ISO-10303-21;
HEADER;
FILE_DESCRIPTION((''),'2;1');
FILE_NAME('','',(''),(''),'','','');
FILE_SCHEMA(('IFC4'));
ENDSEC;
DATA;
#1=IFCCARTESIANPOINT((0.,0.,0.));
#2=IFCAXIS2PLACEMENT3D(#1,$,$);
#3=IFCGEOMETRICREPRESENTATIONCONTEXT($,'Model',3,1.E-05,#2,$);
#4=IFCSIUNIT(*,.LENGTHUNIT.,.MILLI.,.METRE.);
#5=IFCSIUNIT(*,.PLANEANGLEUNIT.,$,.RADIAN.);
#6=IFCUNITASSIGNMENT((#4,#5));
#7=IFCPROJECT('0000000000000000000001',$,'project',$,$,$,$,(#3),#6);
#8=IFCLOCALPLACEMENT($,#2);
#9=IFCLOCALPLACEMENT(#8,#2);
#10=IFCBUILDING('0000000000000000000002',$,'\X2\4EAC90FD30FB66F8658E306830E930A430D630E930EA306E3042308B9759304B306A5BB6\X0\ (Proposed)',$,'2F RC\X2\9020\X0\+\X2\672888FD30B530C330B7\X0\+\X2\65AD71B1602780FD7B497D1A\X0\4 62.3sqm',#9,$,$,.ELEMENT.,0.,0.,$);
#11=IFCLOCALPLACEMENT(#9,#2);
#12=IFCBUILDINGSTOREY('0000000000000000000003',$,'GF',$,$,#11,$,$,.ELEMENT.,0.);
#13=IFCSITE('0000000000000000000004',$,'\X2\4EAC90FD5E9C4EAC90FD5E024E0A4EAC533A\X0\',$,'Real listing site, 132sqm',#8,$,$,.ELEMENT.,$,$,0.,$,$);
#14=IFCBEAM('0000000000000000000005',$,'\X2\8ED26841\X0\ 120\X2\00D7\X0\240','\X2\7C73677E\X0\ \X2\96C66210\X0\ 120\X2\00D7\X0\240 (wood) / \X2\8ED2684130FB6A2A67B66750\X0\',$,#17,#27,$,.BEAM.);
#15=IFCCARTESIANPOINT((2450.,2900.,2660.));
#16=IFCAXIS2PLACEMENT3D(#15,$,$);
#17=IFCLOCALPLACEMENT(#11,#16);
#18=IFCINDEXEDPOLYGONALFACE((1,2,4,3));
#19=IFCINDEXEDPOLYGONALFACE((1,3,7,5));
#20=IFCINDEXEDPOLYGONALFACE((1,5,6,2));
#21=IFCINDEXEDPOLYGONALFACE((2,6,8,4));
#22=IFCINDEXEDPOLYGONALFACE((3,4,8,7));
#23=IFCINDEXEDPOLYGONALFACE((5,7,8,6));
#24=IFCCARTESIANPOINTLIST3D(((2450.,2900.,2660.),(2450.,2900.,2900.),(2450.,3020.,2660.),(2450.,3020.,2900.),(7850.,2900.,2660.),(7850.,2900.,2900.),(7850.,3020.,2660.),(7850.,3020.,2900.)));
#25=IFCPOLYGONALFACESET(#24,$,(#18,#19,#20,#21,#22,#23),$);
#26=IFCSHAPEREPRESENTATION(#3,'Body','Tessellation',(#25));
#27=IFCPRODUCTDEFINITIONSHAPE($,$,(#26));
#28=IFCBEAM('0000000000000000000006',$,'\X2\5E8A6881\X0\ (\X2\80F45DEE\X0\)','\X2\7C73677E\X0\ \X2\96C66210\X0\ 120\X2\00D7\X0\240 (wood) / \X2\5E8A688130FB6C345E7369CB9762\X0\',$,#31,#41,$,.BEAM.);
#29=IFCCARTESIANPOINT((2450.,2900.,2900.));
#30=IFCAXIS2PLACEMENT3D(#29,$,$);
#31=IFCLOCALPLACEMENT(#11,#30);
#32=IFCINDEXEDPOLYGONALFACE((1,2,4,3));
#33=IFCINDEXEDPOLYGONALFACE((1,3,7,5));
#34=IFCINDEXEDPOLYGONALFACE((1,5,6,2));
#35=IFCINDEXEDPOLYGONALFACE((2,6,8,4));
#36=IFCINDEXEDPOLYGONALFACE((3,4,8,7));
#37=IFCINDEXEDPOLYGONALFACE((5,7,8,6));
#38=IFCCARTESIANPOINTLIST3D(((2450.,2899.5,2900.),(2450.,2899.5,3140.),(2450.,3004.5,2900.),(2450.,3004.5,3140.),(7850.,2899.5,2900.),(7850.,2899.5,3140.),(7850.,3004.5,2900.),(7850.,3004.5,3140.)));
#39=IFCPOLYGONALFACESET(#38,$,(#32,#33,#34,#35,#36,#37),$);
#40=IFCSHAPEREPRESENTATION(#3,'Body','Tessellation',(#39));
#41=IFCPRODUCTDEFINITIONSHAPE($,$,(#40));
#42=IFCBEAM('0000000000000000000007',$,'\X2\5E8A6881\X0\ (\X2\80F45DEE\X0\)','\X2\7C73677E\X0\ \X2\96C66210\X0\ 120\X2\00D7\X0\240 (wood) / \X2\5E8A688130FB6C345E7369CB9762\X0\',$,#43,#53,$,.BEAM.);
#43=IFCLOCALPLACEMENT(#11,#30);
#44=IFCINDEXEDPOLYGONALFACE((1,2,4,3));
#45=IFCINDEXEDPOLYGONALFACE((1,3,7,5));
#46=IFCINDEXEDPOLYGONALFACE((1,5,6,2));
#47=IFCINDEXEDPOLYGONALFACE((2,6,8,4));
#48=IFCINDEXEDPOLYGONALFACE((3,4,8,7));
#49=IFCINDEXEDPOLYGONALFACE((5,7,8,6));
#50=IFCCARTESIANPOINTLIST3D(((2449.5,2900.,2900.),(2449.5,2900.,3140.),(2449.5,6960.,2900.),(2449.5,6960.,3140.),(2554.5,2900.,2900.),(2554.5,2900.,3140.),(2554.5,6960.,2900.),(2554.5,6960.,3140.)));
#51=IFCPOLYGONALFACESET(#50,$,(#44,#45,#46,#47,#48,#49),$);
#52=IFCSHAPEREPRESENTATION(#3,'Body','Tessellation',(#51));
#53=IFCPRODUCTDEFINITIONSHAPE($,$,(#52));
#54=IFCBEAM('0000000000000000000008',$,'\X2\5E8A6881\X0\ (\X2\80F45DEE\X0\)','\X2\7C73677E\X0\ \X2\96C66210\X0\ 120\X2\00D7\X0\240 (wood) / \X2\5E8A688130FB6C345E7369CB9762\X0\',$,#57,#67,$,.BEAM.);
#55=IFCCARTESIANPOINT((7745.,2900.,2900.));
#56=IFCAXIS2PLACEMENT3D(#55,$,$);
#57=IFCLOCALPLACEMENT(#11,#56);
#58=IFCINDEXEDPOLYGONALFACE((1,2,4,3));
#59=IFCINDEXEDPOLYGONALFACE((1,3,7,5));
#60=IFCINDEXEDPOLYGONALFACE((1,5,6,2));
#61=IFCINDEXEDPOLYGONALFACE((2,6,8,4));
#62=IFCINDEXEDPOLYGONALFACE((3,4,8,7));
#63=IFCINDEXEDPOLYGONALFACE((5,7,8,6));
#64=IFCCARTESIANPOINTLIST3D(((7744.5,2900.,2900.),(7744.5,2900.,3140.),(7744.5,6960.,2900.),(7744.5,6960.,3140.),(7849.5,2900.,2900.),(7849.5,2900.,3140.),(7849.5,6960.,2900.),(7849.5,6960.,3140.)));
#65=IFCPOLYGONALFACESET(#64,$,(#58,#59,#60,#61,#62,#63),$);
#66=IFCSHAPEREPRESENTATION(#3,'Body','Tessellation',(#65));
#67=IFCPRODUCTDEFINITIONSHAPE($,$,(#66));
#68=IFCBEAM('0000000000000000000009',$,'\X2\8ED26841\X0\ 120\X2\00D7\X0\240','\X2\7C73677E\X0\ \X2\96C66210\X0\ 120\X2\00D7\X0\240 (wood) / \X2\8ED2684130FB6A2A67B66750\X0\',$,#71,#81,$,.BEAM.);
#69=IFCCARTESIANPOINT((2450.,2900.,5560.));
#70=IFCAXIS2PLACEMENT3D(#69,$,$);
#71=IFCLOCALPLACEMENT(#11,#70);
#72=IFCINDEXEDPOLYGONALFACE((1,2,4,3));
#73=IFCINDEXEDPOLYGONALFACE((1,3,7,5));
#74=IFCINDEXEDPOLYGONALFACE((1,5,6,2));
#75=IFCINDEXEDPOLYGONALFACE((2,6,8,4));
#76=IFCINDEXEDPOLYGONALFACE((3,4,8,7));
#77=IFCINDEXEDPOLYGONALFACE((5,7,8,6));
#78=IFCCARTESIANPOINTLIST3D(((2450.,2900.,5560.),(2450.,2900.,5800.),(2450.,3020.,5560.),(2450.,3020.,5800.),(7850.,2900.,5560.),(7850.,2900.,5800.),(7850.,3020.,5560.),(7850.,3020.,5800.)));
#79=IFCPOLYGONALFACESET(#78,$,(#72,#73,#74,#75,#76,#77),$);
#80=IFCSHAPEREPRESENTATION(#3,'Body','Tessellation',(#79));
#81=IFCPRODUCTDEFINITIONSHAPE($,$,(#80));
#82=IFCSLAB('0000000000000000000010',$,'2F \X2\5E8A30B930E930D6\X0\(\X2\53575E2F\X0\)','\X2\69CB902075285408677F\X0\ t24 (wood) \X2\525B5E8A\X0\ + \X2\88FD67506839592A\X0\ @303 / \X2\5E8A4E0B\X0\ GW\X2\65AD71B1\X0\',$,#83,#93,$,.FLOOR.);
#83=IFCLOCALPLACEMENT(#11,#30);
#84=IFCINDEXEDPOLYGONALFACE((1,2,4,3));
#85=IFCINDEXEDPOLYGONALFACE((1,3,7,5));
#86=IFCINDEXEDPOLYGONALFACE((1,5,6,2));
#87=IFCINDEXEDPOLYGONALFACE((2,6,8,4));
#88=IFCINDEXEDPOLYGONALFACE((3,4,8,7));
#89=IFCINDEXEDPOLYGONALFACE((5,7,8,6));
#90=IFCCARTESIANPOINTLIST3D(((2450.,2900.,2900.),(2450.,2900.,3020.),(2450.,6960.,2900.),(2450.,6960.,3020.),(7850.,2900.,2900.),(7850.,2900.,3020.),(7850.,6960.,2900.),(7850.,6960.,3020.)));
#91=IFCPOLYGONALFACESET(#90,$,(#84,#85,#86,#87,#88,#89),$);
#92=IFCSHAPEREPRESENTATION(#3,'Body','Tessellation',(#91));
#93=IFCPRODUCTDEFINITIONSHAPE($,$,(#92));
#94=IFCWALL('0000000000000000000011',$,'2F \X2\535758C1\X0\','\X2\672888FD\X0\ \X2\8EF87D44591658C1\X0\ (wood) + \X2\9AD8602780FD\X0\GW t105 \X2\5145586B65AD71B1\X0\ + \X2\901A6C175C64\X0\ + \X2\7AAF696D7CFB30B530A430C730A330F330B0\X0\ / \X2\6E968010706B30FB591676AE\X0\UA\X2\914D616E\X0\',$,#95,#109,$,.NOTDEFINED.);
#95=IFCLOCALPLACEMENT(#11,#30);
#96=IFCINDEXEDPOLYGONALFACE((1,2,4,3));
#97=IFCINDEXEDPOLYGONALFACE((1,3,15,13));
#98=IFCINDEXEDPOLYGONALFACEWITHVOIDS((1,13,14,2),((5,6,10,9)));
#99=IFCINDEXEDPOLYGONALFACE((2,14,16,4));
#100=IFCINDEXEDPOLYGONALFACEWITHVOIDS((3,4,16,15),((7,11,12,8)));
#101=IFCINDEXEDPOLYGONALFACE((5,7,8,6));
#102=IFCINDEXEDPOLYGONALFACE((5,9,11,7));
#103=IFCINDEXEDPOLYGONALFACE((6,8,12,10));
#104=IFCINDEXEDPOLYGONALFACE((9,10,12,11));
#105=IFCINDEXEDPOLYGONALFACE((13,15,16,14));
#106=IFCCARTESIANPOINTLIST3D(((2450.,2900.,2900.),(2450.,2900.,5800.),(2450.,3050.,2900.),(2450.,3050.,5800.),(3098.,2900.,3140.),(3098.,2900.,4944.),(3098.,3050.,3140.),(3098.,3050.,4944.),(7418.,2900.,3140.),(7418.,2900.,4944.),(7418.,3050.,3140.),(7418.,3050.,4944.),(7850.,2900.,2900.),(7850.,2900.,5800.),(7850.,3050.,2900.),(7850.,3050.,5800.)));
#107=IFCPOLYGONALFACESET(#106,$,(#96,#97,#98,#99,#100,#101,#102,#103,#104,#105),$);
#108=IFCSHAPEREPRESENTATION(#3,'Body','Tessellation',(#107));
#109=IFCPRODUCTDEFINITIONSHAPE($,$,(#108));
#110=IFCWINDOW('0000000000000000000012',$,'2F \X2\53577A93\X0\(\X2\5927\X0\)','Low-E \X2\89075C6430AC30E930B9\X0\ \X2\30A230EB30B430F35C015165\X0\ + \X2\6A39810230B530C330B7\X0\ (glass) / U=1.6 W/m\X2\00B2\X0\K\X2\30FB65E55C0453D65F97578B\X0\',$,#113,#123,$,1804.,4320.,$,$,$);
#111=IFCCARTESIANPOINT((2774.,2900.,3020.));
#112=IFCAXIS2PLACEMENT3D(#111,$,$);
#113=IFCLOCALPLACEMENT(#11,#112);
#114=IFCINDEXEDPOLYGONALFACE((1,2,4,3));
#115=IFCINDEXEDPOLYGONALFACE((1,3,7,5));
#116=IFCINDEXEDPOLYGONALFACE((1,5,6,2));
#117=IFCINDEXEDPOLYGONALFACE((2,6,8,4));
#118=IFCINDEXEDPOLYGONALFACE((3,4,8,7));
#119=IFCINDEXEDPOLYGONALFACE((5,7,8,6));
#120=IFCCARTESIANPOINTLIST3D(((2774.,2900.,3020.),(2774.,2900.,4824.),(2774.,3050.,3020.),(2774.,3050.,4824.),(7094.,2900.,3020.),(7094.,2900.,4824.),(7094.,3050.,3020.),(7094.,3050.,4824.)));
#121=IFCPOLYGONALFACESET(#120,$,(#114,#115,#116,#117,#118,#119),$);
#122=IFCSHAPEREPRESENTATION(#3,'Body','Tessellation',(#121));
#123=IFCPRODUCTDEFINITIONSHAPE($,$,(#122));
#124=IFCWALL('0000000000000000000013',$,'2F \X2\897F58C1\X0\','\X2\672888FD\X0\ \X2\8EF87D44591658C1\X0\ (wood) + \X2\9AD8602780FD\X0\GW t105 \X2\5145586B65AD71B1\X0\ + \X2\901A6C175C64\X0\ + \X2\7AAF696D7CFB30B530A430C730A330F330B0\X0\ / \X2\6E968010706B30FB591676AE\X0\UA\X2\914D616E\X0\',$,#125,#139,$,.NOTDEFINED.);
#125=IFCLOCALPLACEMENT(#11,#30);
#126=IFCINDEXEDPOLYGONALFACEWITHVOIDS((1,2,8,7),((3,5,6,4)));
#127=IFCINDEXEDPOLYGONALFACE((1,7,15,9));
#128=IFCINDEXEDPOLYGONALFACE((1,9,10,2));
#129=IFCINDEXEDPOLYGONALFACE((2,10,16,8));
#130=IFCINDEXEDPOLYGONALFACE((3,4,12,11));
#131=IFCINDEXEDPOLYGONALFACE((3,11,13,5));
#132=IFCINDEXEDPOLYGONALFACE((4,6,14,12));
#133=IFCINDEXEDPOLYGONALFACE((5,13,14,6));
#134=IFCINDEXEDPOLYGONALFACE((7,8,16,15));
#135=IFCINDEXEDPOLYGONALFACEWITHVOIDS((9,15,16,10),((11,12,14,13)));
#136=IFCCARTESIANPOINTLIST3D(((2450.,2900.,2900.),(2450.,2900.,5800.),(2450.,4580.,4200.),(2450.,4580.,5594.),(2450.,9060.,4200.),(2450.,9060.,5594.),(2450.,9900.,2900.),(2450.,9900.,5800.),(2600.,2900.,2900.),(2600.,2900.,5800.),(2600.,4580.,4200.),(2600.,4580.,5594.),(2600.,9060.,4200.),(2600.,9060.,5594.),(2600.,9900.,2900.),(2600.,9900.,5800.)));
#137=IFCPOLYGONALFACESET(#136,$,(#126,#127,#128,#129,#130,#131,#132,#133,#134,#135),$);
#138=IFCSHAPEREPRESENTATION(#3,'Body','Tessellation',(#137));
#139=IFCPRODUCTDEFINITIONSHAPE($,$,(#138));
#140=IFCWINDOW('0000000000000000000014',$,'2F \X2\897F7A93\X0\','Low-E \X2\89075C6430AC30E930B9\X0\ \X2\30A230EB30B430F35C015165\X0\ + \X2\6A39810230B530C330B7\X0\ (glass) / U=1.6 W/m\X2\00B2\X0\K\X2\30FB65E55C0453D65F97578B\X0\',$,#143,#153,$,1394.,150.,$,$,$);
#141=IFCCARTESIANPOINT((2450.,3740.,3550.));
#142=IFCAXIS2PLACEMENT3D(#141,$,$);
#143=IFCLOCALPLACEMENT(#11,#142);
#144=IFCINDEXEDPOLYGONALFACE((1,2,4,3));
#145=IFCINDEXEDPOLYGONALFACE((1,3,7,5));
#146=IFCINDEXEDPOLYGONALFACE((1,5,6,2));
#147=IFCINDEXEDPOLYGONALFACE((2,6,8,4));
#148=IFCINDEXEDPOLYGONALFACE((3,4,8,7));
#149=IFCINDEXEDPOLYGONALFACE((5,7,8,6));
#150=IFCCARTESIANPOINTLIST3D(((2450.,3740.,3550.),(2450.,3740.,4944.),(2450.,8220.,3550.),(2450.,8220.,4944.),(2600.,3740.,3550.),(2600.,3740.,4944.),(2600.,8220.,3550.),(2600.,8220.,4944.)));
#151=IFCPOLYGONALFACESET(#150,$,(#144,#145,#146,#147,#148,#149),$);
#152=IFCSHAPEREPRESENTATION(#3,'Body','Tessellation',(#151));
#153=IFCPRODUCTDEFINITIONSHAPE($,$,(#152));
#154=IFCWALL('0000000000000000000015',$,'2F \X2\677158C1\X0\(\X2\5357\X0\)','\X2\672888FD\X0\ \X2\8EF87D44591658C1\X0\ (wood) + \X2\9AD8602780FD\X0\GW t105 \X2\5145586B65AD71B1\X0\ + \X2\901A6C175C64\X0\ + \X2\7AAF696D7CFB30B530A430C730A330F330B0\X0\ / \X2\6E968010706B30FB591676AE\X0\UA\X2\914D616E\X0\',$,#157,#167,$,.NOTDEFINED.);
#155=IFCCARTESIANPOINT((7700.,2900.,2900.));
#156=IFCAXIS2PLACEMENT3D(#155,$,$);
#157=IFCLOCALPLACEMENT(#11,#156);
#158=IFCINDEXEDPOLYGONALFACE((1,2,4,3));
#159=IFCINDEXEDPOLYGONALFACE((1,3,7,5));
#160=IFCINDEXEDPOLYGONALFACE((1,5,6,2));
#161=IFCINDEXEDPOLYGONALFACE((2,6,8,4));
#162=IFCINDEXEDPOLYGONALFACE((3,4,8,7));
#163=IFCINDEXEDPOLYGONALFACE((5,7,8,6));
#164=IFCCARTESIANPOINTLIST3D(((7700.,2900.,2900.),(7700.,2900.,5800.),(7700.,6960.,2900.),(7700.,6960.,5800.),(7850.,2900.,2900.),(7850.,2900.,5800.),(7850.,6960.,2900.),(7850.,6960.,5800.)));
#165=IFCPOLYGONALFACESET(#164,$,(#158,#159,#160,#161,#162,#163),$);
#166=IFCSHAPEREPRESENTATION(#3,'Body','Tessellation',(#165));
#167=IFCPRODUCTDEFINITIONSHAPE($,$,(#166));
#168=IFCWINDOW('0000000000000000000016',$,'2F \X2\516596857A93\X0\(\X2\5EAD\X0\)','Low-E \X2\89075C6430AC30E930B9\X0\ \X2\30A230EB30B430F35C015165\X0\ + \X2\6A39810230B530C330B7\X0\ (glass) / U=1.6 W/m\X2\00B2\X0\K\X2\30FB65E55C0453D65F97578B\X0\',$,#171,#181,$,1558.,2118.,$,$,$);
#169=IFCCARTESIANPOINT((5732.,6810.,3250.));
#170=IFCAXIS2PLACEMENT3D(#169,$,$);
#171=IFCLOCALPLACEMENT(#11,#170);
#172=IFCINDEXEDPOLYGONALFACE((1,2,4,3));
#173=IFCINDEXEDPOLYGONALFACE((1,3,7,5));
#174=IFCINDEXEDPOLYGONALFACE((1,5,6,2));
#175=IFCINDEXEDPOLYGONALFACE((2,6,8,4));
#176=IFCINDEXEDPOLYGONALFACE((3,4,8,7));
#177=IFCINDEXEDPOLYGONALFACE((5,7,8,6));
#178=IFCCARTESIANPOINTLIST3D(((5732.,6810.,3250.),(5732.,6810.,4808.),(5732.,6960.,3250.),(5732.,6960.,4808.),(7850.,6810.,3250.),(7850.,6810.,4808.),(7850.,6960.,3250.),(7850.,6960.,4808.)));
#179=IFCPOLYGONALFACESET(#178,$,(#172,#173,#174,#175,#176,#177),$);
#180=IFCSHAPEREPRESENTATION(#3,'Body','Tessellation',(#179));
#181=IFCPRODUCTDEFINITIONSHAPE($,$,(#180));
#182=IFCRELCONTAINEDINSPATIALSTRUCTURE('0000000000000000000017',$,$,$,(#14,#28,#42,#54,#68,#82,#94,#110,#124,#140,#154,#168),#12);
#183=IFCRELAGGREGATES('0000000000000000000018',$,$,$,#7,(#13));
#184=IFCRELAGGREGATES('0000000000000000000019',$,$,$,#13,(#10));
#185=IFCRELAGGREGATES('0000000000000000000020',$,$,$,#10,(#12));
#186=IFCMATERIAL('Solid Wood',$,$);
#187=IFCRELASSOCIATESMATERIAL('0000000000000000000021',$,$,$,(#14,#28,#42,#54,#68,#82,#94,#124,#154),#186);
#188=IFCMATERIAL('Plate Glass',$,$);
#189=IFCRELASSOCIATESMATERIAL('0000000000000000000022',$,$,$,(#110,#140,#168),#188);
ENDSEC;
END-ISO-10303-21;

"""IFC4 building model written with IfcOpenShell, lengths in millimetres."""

from ifc_helpers import new_model, si_unit, frame, frame_2d, origin, place, context, project, spatial, rectangle, extrude, material, element, fill, save


model = new_model("IFC4")

# Units and contexts
model_context = context("Model", 3, precision=1e-05, world=origin())
ifc_project = project(units=[si_unit("LENGTHUNIT", "METRE", prefix="MILLI"), si_unit("PLANEANGLEUNIT", "RADIAN")], contexts=[model_context])

# Site, building, storey
site_placement = place(None, origin())
site = spatial("IfcSite", under=ifc_project, at=site_placement, Name="京都府京都市上京区", ObjectType="Real listing site, 132sqm", CompositionType="ELEMENT", RefElevation=0.0)
building_placement = place(site_placement, origin())
building = spatial("IfcBuilding", under=site, at=building_placement, Name="京都・書斎とライブラリのある静かな家 (Proposed)", ObjectType="2F RC造+木製サッシ+断熱性能等級4 62.3sqm", CompositionType="ELEMENT", ElevationOfRefHeight=0.0, ElevationOfTerrain=0.0)
storey_placement = place(building_placement, origin())
storey = spatial("IfcBuildingStorey", under=building, at=storey_placement, Name="GF", CompositionType="ELEMENT", Elevation=0.0)

# Shared definitions
ifc_material_1 = material(Name="Solid Wood")

# Beams
beam_1_placement = place(storey_placement, frame((2450.0, 2900.0, 2660.0)))
element("IfcBeam", 1, at=beam_1_placement, inside=storey, material=ifc_material_1, Name="軒桁 120×240", Description="米松 集成 120×240 (wood) / 軒桁・横架材", PredefinedType="BEAM", context=model_context, shape_type="SweptSolid", body=[
    extrude(rectangle(XDim=5400.0, YDim=120.0, at=frame_2d((2700.0, 60.0))), frame((2450.0, 2900.0, 2660.0)), (0.0, 0.0, 1.0), 240.0),
])
beam_2_placement = place(storey_placement, frame((2450.0, 2900.0, 2900.0)))
element("IfcBeam", 2, at=beam_2_placement, inside=storey, material=ifc_material_1, Name="床梁 (胴差)", Description="米松 集成 120×240 (wood) / 床梁・水平構面", PredefinedType="BEAM", context=model_context, shape_type="SweptSolid", body=[
    extrude(rectangle(XDim=5400.0, YDim=105.0, at=frame_2d((2700.0, 52.0))), frame((2450.0, 2900.0, 2900.0)), (0.0, 0.0, 1.0), 240.0),
])
beam_3_placement = place(storey_placement, frame((2450.0, 2900.0, 2900.0)))
element("IfcBeam", 3, at=beam_3_placement, inside=storey, material=ifc_material_1, Name="床梁 (胴差)", Description="米松 集成 120×240 (wood) / 床梁・水平構面", PredefinedType="BEAM", context=model_context, shape_type="SweptSolid", body=[
    extrude(rectangle(XDim=105.0, YDim=4060.0, at=frame_2d((52.0, 2030.0))), frame((2450.0, 2900.0, 2900.0)), (0.0, 0.0, 1.0), 240.0),
])
beam_4_placement = place(storey_placement, frame((7745.0, 2900.0, 2900.0)))
element("IfcBeam", 4, at=beam_4_placement, inside=storey, material=ifc_material_1, Name="床梁 (胴差)", Description="米松 集成 120×240 (wood) / 床梁・水平構面", PredefinedType="BEAM", context=model_context, shape_type="SweptSolid", body=[
    extrude(rectangle(XDim=105.0, YDim=4060.0, at=frame_2d((52.0, 2030.0))), frame((7745.0, 2900.0, 2900.0)), (0.0, 0.0, 1.0), 240.0),
])
beam_5_placement = place(storey_placement, frame((2450.0, 2900.0, 5560.0)))
element("IfcBeam", 5, at=beam_5_placement, inside=storey, material=ifc_material_1, Name="軒桁 120×240", Description="米松 集成 120×240 (wood) / 軒桁・横架材", PredefinedType="BEAM", context=model_context, shape_type="SweptSolid", body=[
    extrude(rectangle(XDim=5400.0, YDim=120.0, at=frame_2d((2700.0, 60.0))), frame((2450.0, 2900.0, 5560.0)), (0.0, 0.0, 1.0), 240.0),
])

# Slab
slab_placement = place(storey_placement, frame((2450.0, 2900.0, 2900.0)))
element("IfcSlab", 6, at=slab_placement, inside=storey, material=ifc_material_1, Name="2F 床スラブ(南帯)", Description="構造用合板 t24 (wood) 剛床 + 製材根太 @303 / 床下 GW断熱", PredefinedType="FLOOR", context=model_context, shape_type="SweptSolid", body=[
    extrude(rectangle(XDim=5400.0, YDim=4060.0, at=frame_2d((2700.0, 2030.0))), frame((2450.0, 2900.0, 2900.0)), (0.0, 0.0, 1.0), 120.0),
])

# Walls, openings, windows
wall_1_placement = place(storey_placement, frame((2450.0, 2900.0, 2900.0)))
wall_1 = element("IfcWall", 7, at=wall_1_placement, inside=storey, material=ifc_material_1, Name="2F 南壁", Description="木製 軸組外壁 (wood) + 高性能GW t105 充填断熱 + 通気層 + 窯業系サイディング / 準耐火・外皮UA配慮", PredefinedType="NOTDEFINED", context=model_context, shape_type="SweptSolid", body=[
    extrude(rectangle(XDim=5400.0, YDim=150.0, at=frame_2d((2700.0, 75.0))), frame((2450.0, 2900.0, 2900.0)), (0.0, 0.0, 1.0), 2900.0),
])
opening_1_placement = place(storey_placement, frame((2774.0, 2900.0, 3020.0)))
opening_1 = element("IfcOpeningElement", 8, at=opening_1_placement, cuts=wall_1, PredefinedType="NOTDEFINED", context=model_context, shape_type="SweptSolid", body=[
    extrude(rectangle(XDim=4320.0, YDim=150.0, at=frame_2d((2160.0, 75.0))), frame((2774.0, 2900.0, 3020.0)), (0.0, 0.0, 1.0), 1804.0),
])
ifc_material_2 = material(Name="Plate Glass")
window_1_placement = place(storey_placement, frame((2774.0, 2900.0, 3020.0)))
window_1 = element("IfcWindow", 9, at=window_1_placement, inside=storey, material=ifc_material_2, Name="2F 南窓(大)", Description="Low-E 複層ガラス アルゴン封入 + 樹脂サッシ (glass) / U=1.6 W/m²K・日射取得型", OverallHeight=1804.0, OverallWidth=4320.0, context=model_context, shape_type="SweptSolid", body=[
    extrude(rectangle(XDim=4320.0, YDim=150.0, at=frame_2d((2160.0, 75.0))), frame((2774.0, 2900.0, 3020.0)), (0.0, 0.0, 1.0), 1804.0),
])
fill(opening_1, window_1)
wall_2_placement = place(storey_placement, frame((2450.0, 2900.0, 2900.0)))
wall_2 = element("IfcWall", 10, at=wall_2_placement, inside=storey, material=ifc_material_1, Name="2F 西壁", Description="木製 軸組外壁 (wood) + 高性能GW t105 充填断熱 + 通気層 + 窯業系サイディング / 準耐火・外皮UA配慮", PredefinedType="NOTDEFINED", context=model_context, shape_type="SweptSolid", body=[
    extrude(rectangle(XDim=150.0, YDim=7000.0, at=frame_2d((75.0, 3500.0))), frame((2450.0, 2900.0, 2900.0)), (0.0, 0.0, 1.0), 2900.0),
])
opening_2_placement = place(storey_placement, frame((2450.0, 3740.0, 3550.0)))
opening_2 = element("IfcOpeningElement", 11, at=opening_2_placement, cuts=wall_2, PredefinedType="NOTDEFINED", context=model_context, shape_type="SweptSolid", body=[
    extrude(rectangle(XDim=150.0, YDim=4480.0, at=frame_2d((75.0, 2240.0))), frame((2450.0, 3740.0, 3550.0)), (0.0, 0.0, 1.0), 1394.0),
])
window_2_placement = place(storey_placement, frame((2450.0, 3740.0, 3550.0)))
window_2 = element("IfcWindow", 12, at=window_2_placement, inside=storey, material=ifc_material_2, Name="2F 西窓", Description="Low-E 複層ガラス アルゴン封入 + 樹脂サッシ (glass) / U=1.6 W/m²K・日射取得型", OverallHeight=1394.0, OverallWidth=150.0, context=model_context, shape_type="SweptSolid", body=[
    extrude(rectangle(XDim=150.0, YDim=4480.0, at=frame_2d((75.0, 2240.0))), frame((2450.0, 3740.0, 3550.0)), (0.0, 0.0, 1.0), 1394.0),
])
fill(opening_2, window_2)
wall_3_placement = place(storey_placement, frame((7700.0, 2900.0, 2900.0)))
wall_3 = element("IfcWall", 13, at=wall_3_placement, inside=storey, material=ifc_material_1, Name="2F 東壁(南)", Description="木製 軸組外壁 (wood) + 高性能GW t105 充填断熱 + 通気層 + 窯業系サイディング / 準耐火・外皮UA配慮", PredefinedType="NOTDEFINED", context=model_context, shape_type="SweptSolid", body=[
    extrude(rectangle(XDim=150.0, YDim=4060.0, at=frame_2d((75.0, 2030.0))), frame((7700.0, 2900.0, 2900.0)), (0.0, 0.0, 1.0), 2900.0),
])
opening_3_placement = place(storey_placement, frame((5732.0, 6810.0, 3250.0)))
opening_3 = element("IfcOpeningElement", 14, at=opening_3_placement, cuts=wall_3, PredefinedType="NOTDEFINED", context=model_context, shape_type="SweptSolid", body=[
    extrude(rectangle(XDim=2118.0, YDim=150.0, at=frame_2d((1059.0, 75.0))), frame((5732.0, 6810.0, 3250.0)), (0.0, 0.0, 1.0), 1558.0),
])
window_3_placement = place(storey_placement, frame((5732.0, 6810.0, 3250.0)))
window_3 = element("IfcWindow", 15, at=window_3_placement, inside=storey, material=ifc_material_2, Name="2F 入隅窓(庭)", Description="Low-E 複層ガラス アルゴン封入 + 樹脂サッシ (glass) / U=1.6 W/m²K・日射取得型", OverallHeight=1558.0, OverallWidth=2118.0, context=model_context, shape_type="SweptSolid", body=[
    extrude(rectangle(XDim=2118.0, YDim=150.0, at=frame_2d((1059.0, 75.0))), frame((5732.0, 6810.0, 3250.0)), (0.0, 0.0, 1.0), 1558.0),
])
fill(opening_3, window_3)

save(model, "model.ifc")
